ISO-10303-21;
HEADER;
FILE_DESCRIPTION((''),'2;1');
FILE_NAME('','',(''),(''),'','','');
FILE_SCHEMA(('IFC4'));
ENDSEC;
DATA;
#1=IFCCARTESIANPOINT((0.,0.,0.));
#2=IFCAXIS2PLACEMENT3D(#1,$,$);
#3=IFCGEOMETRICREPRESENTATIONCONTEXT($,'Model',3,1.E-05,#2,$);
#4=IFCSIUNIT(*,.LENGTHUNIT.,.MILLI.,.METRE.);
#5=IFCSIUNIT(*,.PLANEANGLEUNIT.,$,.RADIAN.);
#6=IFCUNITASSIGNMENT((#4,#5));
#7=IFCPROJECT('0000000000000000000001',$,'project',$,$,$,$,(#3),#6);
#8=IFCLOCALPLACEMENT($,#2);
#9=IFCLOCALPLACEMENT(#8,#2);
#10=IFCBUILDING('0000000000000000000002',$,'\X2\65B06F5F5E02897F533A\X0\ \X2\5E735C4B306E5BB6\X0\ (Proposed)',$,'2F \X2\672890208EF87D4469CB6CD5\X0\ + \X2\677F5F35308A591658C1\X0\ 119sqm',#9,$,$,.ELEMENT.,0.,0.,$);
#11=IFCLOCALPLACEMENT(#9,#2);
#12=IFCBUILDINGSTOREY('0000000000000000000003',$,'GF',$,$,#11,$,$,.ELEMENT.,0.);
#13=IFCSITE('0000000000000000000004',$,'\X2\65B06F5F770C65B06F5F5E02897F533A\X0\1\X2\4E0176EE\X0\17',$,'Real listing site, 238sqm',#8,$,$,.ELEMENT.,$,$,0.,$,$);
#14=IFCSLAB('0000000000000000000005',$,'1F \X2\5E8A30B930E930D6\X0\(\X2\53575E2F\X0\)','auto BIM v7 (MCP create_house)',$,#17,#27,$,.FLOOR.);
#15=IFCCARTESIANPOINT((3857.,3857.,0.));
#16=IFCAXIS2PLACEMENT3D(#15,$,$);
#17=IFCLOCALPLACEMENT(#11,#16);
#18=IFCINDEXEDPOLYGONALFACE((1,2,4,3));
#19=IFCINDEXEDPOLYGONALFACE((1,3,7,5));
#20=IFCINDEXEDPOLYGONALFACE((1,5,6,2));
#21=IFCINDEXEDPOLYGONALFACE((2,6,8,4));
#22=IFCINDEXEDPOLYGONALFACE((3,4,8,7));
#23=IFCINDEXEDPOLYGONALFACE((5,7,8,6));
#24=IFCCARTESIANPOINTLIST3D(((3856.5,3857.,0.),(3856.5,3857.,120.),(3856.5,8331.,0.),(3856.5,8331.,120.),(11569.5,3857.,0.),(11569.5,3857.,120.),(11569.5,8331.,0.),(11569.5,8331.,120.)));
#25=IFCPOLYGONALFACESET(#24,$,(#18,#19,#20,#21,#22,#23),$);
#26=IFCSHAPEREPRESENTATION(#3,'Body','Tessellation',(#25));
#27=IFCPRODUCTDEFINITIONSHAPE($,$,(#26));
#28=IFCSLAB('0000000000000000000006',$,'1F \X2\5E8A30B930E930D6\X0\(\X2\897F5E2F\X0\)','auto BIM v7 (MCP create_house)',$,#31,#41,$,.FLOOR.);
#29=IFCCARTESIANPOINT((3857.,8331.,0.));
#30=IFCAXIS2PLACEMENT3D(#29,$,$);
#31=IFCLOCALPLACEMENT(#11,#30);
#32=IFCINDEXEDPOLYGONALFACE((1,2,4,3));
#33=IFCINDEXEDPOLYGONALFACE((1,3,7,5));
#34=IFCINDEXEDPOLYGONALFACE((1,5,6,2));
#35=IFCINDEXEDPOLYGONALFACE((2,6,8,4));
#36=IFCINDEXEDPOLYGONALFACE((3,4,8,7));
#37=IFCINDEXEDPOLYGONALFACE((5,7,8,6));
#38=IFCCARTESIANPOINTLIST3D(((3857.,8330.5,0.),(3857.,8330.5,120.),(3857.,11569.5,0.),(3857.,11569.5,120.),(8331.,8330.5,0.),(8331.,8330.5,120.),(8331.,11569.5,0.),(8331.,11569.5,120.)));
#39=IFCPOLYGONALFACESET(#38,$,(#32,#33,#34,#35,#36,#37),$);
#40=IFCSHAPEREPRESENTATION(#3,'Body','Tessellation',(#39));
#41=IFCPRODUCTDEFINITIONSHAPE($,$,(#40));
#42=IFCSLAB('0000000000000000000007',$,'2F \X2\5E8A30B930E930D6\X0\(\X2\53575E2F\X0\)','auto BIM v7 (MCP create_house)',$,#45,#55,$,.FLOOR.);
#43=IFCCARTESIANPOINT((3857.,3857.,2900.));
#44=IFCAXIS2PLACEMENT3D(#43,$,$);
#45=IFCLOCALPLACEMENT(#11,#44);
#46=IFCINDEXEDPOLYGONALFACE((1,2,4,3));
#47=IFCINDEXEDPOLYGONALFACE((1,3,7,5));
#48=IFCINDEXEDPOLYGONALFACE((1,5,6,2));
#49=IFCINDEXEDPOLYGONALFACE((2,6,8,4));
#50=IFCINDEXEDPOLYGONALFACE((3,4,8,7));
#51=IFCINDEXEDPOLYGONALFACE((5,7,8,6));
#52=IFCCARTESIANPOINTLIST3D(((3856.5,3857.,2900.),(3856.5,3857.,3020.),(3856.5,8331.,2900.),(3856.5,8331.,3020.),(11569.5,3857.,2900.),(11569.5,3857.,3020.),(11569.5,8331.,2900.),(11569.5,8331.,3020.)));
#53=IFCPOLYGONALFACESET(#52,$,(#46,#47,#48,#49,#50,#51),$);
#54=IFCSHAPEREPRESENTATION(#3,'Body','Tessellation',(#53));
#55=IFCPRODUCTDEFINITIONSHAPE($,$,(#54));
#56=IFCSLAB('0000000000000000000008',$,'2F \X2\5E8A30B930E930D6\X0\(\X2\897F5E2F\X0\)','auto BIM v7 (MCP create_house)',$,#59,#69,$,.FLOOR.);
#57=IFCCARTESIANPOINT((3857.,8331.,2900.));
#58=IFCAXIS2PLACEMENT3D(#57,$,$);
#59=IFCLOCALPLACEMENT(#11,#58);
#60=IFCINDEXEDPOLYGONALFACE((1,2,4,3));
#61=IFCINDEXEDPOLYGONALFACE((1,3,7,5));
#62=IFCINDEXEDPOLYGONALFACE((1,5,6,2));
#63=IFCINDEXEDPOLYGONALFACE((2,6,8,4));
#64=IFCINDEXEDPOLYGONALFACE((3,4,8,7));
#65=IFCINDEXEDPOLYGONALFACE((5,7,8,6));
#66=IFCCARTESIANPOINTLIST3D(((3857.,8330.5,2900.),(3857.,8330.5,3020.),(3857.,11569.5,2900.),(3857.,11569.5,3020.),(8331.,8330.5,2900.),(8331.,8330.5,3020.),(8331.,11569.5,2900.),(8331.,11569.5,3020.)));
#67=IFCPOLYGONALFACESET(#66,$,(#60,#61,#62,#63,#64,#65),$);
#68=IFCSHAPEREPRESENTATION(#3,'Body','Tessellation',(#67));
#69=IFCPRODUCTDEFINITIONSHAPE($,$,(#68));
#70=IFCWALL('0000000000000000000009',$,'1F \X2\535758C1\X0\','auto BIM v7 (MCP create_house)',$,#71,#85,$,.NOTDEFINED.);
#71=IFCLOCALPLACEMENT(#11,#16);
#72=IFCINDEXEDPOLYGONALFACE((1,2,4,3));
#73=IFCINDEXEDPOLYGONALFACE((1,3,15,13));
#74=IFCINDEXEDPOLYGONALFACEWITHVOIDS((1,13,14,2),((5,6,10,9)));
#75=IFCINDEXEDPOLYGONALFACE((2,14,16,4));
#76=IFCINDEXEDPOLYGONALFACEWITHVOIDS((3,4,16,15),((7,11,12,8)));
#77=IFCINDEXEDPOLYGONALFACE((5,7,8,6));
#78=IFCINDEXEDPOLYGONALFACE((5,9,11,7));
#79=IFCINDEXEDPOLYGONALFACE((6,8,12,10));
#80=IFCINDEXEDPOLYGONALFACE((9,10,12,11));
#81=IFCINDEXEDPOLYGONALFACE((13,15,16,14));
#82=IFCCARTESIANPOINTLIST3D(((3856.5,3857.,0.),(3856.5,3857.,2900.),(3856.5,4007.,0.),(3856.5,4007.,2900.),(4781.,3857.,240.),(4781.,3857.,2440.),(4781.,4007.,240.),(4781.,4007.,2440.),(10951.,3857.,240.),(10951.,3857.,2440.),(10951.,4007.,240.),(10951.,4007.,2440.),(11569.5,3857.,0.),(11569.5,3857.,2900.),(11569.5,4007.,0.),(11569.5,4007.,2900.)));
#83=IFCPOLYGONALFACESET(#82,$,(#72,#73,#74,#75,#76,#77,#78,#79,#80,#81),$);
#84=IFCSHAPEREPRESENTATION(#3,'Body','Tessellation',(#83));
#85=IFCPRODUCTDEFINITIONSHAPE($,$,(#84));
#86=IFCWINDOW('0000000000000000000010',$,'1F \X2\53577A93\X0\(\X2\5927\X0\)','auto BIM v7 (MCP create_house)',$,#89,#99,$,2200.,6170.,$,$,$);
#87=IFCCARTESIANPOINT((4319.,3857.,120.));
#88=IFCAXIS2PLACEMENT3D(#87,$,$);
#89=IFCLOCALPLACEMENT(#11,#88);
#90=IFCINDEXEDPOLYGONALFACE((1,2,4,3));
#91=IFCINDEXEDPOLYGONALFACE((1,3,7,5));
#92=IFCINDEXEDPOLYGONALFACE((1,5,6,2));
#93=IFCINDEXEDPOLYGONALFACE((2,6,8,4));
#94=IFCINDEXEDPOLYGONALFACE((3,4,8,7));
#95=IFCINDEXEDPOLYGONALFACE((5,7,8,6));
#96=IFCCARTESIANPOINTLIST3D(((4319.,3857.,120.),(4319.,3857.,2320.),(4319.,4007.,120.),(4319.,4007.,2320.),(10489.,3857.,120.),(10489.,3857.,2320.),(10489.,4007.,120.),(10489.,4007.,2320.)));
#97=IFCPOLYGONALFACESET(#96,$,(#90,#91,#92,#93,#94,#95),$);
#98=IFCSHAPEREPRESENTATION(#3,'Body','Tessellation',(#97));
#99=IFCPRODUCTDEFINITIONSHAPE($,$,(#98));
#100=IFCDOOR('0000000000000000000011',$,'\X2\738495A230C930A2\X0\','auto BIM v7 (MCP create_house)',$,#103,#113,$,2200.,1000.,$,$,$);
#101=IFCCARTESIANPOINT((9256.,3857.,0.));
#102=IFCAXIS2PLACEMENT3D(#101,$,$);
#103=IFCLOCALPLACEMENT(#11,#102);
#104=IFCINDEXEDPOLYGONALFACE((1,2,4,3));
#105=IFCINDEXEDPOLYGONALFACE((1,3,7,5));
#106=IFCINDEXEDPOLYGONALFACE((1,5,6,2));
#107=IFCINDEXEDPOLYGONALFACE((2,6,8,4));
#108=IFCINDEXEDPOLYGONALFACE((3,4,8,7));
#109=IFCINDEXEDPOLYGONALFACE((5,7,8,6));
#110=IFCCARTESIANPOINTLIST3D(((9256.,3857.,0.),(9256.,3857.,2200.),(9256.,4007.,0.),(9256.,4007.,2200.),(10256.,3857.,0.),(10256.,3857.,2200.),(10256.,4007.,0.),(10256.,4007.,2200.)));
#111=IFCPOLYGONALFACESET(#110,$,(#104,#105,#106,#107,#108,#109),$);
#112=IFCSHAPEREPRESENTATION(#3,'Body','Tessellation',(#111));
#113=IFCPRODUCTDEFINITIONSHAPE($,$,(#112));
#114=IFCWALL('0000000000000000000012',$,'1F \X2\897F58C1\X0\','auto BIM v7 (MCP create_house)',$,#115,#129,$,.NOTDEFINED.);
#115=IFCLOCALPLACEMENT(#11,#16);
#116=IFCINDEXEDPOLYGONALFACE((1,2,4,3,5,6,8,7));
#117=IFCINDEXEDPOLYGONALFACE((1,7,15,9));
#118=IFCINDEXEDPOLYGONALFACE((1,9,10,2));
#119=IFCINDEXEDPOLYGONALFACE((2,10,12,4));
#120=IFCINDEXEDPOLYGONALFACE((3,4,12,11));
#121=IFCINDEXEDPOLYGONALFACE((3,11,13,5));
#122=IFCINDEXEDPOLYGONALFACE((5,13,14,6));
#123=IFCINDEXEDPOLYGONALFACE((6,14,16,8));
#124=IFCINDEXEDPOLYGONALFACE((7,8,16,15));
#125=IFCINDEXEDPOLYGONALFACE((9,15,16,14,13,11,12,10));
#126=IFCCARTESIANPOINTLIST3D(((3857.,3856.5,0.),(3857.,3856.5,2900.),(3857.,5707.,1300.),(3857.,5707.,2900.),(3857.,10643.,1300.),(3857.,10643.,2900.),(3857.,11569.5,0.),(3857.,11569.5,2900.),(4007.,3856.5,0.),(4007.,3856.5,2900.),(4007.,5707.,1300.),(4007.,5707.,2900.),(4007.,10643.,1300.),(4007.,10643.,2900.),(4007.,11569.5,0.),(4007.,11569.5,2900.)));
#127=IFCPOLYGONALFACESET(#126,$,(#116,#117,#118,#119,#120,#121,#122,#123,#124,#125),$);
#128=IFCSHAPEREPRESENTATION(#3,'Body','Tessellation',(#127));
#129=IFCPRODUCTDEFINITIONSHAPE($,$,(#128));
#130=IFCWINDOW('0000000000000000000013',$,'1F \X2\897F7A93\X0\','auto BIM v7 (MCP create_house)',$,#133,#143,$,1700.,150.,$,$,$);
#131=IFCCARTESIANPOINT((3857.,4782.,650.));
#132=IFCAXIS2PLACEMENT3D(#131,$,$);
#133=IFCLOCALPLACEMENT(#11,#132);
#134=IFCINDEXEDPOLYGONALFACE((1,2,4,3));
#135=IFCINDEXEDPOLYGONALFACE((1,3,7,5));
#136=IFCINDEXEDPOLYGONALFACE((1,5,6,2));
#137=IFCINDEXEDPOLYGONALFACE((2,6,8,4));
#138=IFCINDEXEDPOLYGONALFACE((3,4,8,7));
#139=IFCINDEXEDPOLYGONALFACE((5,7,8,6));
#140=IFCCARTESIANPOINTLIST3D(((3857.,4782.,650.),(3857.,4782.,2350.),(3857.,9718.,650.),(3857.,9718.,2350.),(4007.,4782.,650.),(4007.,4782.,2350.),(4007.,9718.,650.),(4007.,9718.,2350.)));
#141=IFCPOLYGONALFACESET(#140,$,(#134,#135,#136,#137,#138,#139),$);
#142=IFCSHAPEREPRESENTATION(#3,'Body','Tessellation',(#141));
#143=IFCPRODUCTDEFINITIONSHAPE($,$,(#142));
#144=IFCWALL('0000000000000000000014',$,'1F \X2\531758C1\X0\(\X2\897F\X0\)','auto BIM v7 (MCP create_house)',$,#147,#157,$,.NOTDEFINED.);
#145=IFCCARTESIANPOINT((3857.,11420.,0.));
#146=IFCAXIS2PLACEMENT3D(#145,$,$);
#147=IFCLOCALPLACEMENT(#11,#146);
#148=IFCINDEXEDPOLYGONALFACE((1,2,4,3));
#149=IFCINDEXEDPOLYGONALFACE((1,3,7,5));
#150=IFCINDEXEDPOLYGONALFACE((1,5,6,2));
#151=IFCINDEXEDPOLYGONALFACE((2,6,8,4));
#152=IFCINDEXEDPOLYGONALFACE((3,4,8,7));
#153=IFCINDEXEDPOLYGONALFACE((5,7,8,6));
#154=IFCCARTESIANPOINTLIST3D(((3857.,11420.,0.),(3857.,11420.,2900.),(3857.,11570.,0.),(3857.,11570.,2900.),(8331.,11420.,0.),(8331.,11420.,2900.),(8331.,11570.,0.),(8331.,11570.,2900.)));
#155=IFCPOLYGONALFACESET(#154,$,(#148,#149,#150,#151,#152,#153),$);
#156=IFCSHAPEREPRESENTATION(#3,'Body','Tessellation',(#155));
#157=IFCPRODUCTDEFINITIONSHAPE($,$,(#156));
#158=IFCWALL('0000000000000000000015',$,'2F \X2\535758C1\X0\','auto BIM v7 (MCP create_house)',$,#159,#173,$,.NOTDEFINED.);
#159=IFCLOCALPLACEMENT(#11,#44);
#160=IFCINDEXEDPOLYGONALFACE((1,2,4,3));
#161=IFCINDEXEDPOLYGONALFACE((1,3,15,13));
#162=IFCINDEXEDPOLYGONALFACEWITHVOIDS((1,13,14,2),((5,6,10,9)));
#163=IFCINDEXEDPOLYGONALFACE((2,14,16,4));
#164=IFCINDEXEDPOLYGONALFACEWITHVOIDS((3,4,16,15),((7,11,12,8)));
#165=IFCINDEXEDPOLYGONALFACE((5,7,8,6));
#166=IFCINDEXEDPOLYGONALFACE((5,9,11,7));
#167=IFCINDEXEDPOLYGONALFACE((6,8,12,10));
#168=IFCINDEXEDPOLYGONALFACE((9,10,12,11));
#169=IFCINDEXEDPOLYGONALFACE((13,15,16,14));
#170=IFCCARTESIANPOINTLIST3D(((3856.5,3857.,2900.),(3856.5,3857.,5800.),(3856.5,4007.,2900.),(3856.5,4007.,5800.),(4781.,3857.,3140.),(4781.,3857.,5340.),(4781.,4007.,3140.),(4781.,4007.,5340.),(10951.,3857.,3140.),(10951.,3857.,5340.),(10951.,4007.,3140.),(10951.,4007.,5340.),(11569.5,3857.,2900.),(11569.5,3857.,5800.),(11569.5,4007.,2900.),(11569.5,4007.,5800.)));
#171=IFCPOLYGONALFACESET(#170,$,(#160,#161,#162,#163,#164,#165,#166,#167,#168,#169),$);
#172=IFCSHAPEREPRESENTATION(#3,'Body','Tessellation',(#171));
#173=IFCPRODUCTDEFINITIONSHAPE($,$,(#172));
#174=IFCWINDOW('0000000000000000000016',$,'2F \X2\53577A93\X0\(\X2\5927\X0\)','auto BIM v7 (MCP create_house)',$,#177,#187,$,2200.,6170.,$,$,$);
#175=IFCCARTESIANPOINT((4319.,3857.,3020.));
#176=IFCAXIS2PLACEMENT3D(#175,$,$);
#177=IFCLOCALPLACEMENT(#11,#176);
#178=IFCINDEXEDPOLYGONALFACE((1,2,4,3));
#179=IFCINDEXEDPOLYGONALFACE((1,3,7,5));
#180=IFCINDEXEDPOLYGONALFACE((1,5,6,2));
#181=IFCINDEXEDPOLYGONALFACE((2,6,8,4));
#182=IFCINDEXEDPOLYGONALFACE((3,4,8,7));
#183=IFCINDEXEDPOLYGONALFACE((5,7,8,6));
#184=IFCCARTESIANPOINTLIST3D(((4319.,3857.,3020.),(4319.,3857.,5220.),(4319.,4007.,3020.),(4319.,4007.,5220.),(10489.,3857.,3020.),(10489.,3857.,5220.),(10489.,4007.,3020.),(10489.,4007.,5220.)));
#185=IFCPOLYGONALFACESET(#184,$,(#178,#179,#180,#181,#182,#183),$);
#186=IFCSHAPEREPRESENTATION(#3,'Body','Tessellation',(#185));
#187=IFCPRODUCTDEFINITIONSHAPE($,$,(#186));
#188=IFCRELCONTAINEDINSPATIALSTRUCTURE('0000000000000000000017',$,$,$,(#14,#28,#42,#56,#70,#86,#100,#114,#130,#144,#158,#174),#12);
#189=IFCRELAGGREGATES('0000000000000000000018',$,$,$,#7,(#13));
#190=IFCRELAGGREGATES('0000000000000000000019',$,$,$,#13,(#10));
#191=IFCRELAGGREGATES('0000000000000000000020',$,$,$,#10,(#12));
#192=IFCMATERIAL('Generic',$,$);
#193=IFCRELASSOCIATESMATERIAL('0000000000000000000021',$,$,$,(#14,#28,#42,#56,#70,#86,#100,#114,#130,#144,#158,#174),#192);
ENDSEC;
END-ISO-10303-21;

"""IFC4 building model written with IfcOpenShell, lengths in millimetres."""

from ifc_helpers import new_model, si_unit, frame, frame_2d, origin, place, context, project, spatial, rectangle, extrude, material, element, fill, save


model = new_model("IFC4")

# Units and contexts
model_context = context("Model", 3, precision=1e-05, world=origin())
ifc_project = project(units=[si_unit("LENGTHUNIT", "METRE", prefix="MILLI"), si_unit("PLANEANGLEUNIT", "RADIAN")], contexts=[model_context])

# Site, building, storey
site_placement = place(None, origin())
site = spatial("IfcSite", under=ifc_project, at=site_placement, Name="新潟県新潟市西区1丁目17", ObjectType="Real listing site, 238sqm", CompositionType="ELEMENT", RefElevation=0.0)
building_placement = place(site_placement, origin())
building = spatial("IfcBuilding", under=site, at=building_placement, Name="新潟市西区 平屋の家 (Proposed)", ObjectType="2F 木造軸組構法 + 板張り外壁 119sqm", CompositionType="ELEMENT", ElevationOfRefHeight=0.0, ElevationOfTerrain=0.0)
storey_placement = place(building_placement, origin())
storey = spatial("IfcBuildingStorey", under=building, at=storey_placement, Name="GF", CompositionType="ELEMENT", Elevation=0.0)

# Slabs
ifc_material = material(Name="Generic")
slab_1_placement = place(storey_placement, frame((3857.0, 3857.0, 0.0)))
element("IfcSlab", 1, at=slab_1_placement, inside=storey, material=ifc_material, Name="1F 床スラブ(南帯)", Description="auto BIM v7 (MCP create_house)", PredefinedType="FLOOR", context=model_context, shape_type="SweptSolid", body=[
    extrude(rectangle(XDim=7713.0, YDim=4474.0, at=frame_2d((3856.0, 2237.0))), frame((3857.0, 3857.0, 0.0)), (0.0, 0.0, 1.0), 120.0),
])
slab_2_placement = place(storey_placement, frame((3857.0, 8331.0, 0.0)))
element("IfcSlab", 2, at=slab_2_placement, inside=storey, material=ifc_material, Name="1F 床スラブ(西帯)", Description="auto BIM v7 (MCP create_house)", PredefinedType="FLOOR", context=model_context, shape_type="SweptSolid", body=[
    extrude(rectangle(XDim=4474.0, YDim=3239.0, at=frame_2d((2237.0, 1619.0))), frame((3857.0, 8331.0, 0.0)), (0.0, 0.0, 1.0), 120.0),
])
slab_3_placement = place(storey_placement, frame((3857.0, 3857.0, 2900.0)))
element("IfcSlab", 3, at=slab_3_placement, inside=storey, material=ifc_material, Name="2F 床スラブ(南帯)", Description="auto BIM v7 (MCP create_house)", PredefinedType="FLOOR", context=model_context, shape_type="SweptSolid", body=[
    extrude(rectangle(XDim=7713.0, YDim=4474.0, at=frame_2d((3856.0, 2237.0))), frame((3857.0, 3857.0, 2900.0)), (0.0, 0.0, 1.0), 120.0),
])
slab_4_placement = place(storey_placement, frame((3857.0, 8331.0, 2900.0)))
element("IfcSlab", 4, at=slab_4_placement, inside=storey, material=ifc_material, Name="2F 床スラブ(西帯)", Description="auto BIM v7 (MCP create_house)", PredefinedType="FLOOR", context=model_context, shape_type="SweptSolid", body=[
    extrude(rectangle(XDim=4474.0, YDim=3239.0, at=frame_2d((2237.0, 1619.0))), frame((3857.0, 8331.0, 2900.0)), (0.0, 0.0, 1.0), 120.0),
])

# Wall, openings, window, door
wall_1_placement = place(storey_placement, frame((3857.0, 3857.0, 0.0)))
wall_1 = element("IfcWall", 5, at=wall_1_placement, inside=storey, material=ifc_material, Name="1F 南壁", Description="auto BIM v7 (MCP create_house)", PredefinedType="NOTDEFINED", context=model_context, shape_type="SweptSolid", body=[
    extrude(rectangle(XDim=7713.0, YDim=150.0, at=frame_2d((3856.0, 75.0))), frame((3857.0, 3857.0, 0.0)), (0.0, 0.0, 1.0), 2900.0),
])
opening_1_placement = place(storey_placement, frame((4319.0, 3857.0, 120.0)))
opening_1 = element("IfcOpeningElement", 6, at=opening_1_placement, cuts=wall_1, PredefinedType="NOTDEFINED", context=model_context, shape_type="SweptSolid", body=[
    extrude(rectangle(XDim=6170.0, YDim=150.0, at=frame_2d((3085.0, 75.0))), frame((4319.0, 3857.0, 120.0)), (0.0, 0.0, 1.0), 2200.0),
])
opening_2_placement = place(storey_placement, frame((9256.0, 3857.0, 0.0)))
opening_2 = element("IfcOpeningElement", 7, at=opening_2_placement, cuts=wall_1, PredefinedType="NOTDEFINED", context=model_context, shape_type="SweptSolid", body=[
    extrude(rectangle(XDim=1000.0, YDim=150.0, at=frame_2d((500.0, 75.0))), frame((9256.0, 3857.0, 0.0)), (0.0, 0.0, 1.0), 2200.0),
])
window_1_placement = place(storey_placement, frame((4319.0, 3857.0, 120.0)))
window_1 = element("IfcWindow", 8, at=window_1_placement, inside=storey, material=ifc_material, Name="1F 南窓(大)", Description="auto BIM v7 (MCP create_house)", OverallHeight=2200.0, OverallWidth=6170.0, context=model_context, shape_type="SweptSolid", body=[
    extrude(rectangle(XDim=6170.0, YDim=150.0, at=frame_2d((3085.0, 75.0))), frame((4319.0, 3857.0, 120.0)), (0.0, 0.0, 1.0), 2200.0),
])
fill(opening_1, window_1)
door_placement = place(storey_placement, frame((9256.0, 3857.0, 0.0)))
door = element("IfcDoor", 9, at=door_placement, inside=storey, material=ifc_material, Name="玄関ドア", Description="auto BIM v7 (MCP create_house)", OverallHeight=2200.0, OverallWidth=1000.0, context=model_context, shape_type="SweptSolid", body=[
    extrude(rectangle(XDim=1000.0, YDim=150.0, at=frame_2d((500.0, 75.0))), frame((9256.0, 3857.0, 0.0)), (0.0, 0.0, 1.0), 2200.0),
])
fill(opening_2, door)

# Wall, opening, window
wall_2_placement = place(storey_placement, frame((3857.0, 3857.0, 0.0)))
wall_2 = element("IfcWall", 10, at=wall_2_placement, inside=storey, material=ifc_material, Name="1F 西壁", Description="auto BIM v7 (MCP create_house)", PredefinedType="NOTDEFINED", context=model_context, shape_type="SweptSolid", body=[
    extrude(rectangle(XDim=150.0, YDim=7713.0, at=frame_2d((75.0, 3856.0))), frame((3857.0, 3857.0, 0.0)), (0.0, 0.0, 1.0), 2900.0),
])
opening_3_placement = place(storey_placement, frame((3857.0, 4782.0, 650.0)))
opening_3 = element("IfcOpeningElement", 11, at=opening_3_placement, cuts=wall_2, PredefinedType="NOTDEFINED", context=model_context, shape_type="SweptSolid", body=[
    extrude(rectangle(XDim=150.0, YDim=4936.0, at=frame_2d((75.0, 2468.0))), frame((3857.0, 4782.0, 650.0)), (0.0, 0.0, 1.0), 1700.0),
])
window_2_placement = place(storey_placement, frame((3857.0, 4782.0, 650.0)))
window_2 = element("IfcWindow", 12, at=window_2_placement, inside=storey, material=ifc_material, Name="1F 西窓", Description="auto BIM v7 (MCP create_house)", OverallHeight=1700.0, OverallWidth=150.0, context=model_context, shape_type="SweptSolid", body=[
    extrude(rectangle(XDim=150.0, YDim=4936.0, at=frame_2d((75.0, 2468.0))), frame((3857.0, 4782.0, 650.0)), (0.0, 0.0, 1.0), 1700.0),
])
fill(opening_3, window_2)

# Wall
wall_3_placement = place(storey_placement, frame((3857.0, 11420.0, 0.0)))
element("IfcWall", 13, at=wall_3_placement, inside=storey, material=ifc_material, Name="1F 北壁(西)", Description="auto BIM v7 (MCP create_house)", PredefinedType="NOTDEFINED", context=model_context, shape_type="SweptSolid", body=[
    extrude(rectangle(XDim=4474.0, YDim=150.0, at=frame_2d((2237.0, 75.0))), frame((3857.0, 11420.0, 0.0)), (0.0, 0.0, 1.0), 2900.0),
])

# Wall, opening, window
wall_4_placement = place(storey_placement, frame((3857.0, 3857.0, 2900.0)))
wall_4 = element("IfcWall", 14, at=wall_4_placement, inside=storey, material=ifc_material, Name="2F 南壁", Description="auto BIM v7 (MCP create_house)", PredefinedType="NOTDEFINED", context=model_context, shape_type="SweptSolid", body=[
    extrude(rectangle(XDim=7713.0, YDim=150.0, at=frame_2d((3856.0, 75.0))), frame((3857.0, 3857.0, 2900.0)), (0.0, 0.0, 1.0), 2900.0),
])
opening_4_placement = place(storey_placement, frame((4319.0, 3857.0, 3020.0)))
opening_4 = element("IfcOpeningElement", 15, at=opening_4_placement, cuts=wall_4, PredefinedType="NOTDEFINED", context=model_context, shape_type="SweptSolid", body=[
    extrude(rectangle(XDim=6170.0, YDim=150.0, at=frame_2d((3085.0, 75.0))), frame((4319.0, 3857.0, 3020.0)), (0.0, 0.0, 1.0), 2200.0),
])
window_3_placement = place(storey_placement, frame((4319.0, 3857.0, 3020.0)))
window_3 = element("IfcWindow", 16, at=window_3_placement, inside=storey, material=ifc_material, Name="2F 南窓(大)", Description="auto BIM v7 (MCP create_house)", OverallHeight=2200.0, OverallWidth=6170.0, context=model_context, shape_type="SweptSolid", body=[
    extrude(rectangle(XDim=6170.0, YDim=150.0, at=frame_2d((3085.0, 75.0))), frame((4319.0, 3857.0, 3020.0)), (0.0, 0.0, 1.0), 2200.0),
])
fill(opening_4, window_3)

save(model, "model.ifc")
